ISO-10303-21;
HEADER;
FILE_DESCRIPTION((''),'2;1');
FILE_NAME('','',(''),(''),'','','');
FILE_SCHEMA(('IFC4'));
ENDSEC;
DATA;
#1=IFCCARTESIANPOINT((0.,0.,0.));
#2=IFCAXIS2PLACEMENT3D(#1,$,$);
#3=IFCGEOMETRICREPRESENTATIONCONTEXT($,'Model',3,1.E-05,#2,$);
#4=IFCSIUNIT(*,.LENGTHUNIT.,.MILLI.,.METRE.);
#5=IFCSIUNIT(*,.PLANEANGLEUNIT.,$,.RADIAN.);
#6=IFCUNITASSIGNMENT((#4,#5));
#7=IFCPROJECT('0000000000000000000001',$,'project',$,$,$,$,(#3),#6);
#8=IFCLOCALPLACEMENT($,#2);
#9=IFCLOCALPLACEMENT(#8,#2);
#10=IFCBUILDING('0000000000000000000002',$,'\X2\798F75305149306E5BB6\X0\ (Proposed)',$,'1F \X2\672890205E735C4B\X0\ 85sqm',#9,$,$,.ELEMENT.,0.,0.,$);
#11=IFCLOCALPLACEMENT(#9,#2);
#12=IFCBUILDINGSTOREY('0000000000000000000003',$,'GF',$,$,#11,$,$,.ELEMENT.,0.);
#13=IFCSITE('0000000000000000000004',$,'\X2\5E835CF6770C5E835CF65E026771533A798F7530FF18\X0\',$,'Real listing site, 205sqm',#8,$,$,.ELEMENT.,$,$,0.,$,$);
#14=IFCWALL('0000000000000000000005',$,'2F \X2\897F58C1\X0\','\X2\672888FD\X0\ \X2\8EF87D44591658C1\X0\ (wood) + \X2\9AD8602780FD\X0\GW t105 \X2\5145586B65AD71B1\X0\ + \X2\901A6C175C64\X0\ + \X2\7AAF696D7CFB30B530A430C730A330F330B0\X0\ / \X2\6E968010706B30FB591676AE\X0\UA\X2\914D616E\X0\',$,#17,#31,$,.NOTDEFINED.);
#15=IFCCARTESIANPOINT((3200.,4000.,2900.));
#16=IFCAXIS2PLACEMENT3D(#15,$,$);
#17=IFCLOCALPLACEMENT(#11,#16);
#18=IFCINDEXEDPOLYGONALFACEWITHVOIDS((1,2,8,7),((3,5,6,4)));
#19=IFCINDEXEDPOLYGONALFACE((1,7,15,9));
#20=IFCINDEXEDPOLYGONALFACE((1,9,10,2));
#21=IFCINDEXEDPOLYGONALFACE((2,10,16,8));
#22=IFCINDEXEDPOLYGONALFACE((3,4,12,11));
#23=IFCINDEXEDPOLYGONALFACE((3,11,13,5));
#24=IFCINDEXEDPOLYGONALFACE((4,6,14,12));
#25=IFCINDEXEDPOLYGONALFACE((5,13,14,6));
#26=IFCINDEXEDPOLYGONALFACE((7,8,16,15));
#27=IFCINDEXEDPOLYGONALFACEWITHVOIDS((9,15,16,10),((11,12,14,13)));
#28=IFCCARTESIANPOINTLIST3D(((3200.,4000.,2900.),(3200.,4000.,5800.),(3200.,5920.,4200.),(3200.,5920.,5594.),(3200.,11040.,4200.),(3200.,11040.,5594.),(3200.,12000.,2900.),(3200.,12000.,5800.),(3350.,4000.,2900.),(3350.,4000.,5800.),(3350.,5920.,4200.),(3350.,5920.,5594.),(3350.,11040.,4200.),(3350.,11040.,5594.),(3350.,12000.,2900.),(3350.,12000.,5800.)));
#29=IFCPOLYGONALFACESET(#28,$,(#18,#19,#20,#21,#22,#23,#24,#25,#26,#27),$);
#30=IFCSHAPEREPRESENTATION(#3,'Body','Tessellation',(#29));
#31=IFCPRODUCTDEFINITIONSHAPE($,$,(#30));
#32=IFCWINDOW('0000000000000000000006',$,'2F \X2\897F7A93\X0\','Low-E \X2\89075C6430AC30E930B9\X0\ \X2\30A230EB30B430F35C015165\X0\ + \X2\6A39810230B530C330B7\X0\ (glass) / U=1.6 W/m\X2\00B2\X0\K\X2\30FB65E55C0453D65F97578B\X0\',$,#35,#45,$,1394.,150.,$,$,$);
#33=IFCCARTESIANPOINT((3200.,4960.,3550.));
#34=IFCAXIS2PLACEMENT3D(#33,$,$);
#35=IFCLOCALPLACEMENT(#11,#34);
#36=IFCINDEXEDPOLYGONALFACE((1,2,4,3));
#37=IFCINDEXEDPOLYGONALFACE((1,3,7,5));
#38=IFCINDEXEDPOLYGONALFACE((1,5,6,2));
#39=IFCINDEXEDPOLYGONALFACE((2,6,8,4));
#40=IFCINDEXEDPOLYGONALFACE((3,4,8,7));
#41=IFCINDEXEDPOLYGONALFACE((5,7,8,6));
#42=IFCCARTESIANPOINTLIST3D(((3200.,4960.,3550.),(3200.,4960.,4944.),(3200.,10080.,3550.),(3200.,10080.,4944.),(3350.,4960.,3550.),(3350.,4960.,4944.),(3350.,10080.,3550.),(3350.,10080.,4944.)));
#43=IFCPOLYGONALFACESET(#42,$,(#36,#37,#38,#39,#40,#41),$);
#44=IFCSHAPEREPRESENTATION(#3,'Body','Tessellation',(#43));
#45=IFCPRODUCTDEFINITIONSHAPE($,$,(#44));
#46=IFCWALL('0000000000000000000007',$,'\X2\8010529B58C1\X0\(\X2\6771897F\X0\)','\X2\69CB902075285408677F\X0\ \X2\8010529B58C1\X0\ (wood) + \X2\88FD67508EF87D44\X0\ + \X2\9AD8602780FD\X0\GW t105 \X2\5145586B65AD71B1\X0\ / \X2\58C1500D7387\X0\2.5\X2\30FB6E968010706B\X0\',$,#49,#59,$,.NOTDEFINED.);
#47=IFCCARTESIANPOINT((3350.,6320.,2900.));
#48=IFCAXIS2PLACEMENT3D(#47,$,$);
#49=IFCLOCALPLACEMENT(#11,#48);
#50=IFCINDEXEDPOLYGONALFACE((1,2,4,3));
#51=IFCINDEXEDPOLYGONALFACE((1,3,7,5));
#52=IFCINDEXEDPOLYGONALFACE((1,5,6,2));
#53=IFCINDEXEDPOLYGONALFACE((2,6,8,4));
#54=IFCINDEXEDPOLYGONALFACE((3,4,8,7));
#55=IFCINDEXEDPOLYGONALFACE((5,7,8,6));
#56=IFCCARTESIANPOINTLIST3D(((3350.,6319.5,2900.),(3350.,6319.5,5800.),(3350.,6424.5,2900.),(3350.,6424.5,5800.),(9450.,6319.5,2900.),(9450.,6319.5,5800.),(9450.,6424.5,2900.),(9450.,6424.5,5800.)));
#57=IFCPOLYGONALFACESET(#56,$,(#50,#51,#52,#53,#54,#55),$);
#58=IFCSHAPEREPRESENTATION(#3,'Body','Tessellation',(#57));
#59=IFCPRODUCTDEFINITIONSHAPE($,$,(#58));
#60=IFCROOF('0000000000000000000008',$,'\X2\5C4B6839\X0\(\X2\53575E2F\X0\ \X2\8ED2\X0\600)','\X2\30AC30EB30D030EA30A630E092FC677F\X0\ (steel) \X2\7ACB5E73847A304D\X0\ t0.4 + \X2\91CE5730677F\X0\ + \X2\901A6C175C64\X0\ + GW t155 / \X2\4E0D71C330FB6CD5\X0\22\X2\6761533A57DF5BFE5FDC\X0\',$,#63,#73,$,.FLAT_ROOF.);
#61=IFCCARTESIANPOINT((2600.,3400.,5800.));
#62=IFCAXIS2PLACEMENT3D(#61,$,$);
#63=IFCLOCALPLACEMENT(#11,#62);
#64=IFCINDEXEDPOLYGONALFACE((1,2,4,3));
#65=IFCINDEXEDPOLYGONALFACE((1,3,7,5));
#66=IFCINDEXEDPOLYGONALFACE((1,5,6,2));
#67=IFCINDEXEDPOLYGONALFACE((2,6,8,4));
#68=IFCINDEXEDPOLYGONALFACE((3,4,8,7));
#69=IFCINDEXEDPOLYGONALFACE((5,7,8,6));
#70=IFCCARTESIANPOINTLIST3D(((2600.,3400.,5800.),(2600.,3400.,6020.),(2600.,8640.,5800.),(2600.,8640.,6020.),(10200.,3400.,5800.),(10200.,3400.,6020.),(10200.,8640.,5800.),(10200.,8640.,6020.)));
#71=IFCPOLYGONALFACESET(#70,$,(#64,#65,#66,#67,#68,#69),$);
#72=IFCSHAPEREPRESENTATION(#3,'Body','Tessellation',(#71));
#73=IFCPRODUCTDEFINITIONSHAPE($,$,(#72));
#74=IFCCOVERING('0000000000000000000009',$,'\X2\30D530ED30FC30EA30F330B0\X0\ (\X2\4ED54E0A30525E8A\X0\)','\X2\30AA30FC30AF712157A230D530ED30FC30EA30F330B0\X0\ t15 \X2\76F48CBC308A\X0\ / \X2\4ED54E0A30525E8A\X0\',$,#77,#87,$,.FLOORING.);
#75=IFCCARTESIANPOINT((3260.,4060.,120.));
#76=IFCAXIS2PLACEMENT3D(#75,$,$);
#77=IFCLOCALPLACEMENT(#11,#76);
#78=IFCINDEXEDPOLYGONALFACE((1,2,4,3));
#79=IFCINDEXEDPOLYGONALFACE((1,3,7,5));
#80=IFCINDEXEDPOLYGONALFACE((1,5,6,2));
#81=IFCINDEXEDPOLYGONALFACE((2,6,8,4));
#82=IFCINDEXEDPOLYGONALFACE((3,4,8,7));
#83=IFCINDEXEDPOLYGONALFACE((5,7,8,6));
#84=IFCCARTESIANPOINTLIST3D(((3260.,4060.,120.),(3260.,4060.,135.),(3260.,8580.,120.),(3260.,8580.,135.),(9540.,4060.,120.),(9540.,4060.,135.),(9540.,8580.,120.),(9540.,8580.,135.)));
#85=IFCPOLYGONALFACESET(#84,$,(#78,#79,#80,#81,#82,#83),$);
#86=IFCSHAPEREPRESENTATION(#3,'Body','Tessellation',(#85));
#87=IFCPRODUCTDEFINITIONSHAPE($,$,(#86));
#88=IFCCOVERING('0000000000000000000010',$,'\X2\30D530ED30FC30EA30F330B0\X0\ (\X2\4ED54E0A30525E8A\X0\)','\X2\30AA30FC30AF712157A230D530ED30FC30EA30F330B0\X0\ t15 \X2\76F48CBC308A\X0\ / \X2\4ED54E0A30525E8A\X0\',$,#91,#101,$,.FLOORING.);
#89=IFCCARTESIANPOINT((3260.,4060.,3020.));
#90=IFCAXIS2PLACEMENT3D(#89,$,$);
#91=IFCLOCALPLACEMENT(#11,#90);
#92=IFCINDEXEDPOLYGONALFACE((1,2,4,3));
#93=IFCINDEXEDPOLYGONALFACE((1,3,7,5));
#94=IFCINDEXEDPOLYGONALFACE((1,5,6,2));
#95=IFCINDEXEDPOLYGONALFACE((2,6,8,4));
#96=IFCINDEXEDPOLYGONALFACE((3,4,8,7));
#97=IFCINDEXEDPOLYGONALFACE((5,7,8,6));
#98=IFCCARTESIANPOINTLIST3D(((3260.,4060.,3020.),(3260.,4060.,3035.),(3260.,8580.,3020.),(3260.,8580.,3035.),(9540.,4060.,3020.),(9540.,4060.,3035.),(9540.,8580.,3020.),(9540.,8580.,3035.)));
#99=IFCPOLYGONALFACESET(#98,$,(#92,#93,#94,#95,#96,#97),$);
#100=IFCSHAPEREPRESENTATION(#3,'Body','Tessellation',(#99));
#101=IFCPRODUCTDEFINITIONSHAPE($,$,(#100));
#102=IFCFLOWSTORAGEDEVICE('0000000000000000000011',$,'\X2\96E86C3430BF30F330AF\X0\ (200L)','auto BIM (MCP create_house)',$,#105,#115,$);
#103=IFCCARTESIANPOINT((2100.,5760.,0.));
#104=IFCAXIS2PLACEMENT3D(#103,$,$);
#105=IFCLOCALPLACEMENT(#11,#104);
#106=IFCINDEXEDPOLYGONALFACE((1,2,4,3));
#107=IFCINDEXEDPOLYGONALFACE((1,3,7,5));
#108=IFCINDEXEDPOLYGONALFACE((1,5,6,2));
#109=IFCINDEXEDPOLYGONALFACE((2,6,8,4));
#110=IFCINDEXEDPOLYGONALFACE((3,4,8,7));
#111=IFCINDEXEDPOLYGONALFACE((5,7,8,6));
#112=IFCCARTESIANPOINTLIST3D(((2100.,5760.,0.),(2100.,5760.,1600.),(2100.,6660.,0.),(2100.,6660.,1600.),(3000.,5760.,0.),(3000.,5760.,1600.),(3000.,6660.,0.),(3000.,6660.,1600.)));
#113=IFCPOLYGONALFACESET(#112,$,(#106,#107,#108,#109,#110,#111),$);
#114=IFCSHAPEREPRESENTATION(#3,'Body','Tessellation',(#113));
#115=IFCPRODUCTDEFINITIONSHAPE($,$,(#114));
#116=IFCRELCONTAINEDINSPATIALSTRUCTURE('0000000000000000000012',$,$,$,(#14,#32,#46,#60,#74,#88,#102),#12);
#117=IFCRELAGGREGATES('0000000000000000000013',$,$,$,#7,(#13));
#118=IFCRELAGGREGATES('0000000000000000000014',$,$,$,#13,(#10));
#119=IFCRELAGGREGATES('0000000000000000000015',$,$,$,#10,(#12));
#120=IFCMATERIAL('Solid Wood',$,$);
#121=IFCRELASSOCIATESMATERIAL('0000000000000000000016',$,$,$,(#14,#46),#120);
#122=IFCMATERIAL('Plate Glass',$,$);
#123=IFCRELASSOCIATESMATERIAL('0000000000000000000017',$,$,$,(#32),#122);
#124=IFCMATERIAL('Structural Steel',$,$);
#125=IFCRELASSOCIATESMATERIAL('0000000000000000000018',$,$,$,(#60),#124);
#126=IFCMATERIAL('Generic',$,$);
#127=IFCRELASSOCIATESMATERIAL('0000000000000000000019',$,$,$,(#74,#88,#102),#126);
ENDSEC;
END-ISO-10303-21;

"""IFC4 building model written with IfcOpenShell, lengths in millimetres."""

from ifc_helpers import new_model, si_unit, frame, frame_2d, origin, place, context, project, spatial, rectangle, extrude, material, element, fill, save


model = new_model("IFC4")

# Units and contexts
model_context = context("Model", 3, precision=1e-05, world=origin())
ifc_project = project(units=[si_unit("LENGTHUNIT", "METRE", prefix="MILLI"), si_unit("PLANEANGLEUNIT", "RADIAN")], contexts=[model_context])

# Site, building, storey
site_placement = place(None, origin())
site = spatial("IfcSite", under=ifc_project, at=site_placement, Name="広島県広島市東区福田８", ObjectType="Real listing site, 205sqm", CompositionType="ELEMENT", RefElevation=0.0)
building_placement = place(site_placement, origin())
building = spatial("IfcBuilding", under=site, at=building_placement, Name="福田光の家 (Proposed)", ObjectType="1F 木造平屋 85sqm", CompositionType="ELEMENT", ElevationOfRefHeight=0.0, ElevationOfTerrain=0.0)
storey_placement = place(building_placement, origin())
storey = spatial("IfcBuildingStorey", under=building, at=storey_placement, Name="GF", CompositionType="ELEMENT", Elevation=0.0)

# Shared definitions
ifc_material_1 = material(Name="Solid Wood")
ifc_material_2 = material(Name="Generic")

# Shared definitions
ifc_material_3 = material(Name="Plate Glass")

# Wall, opening, window
wall_1_placement = place(storey_placement, frame((3200.0, 4000.0, 2900.0)))
wall_1 = element("IfcWall", 1, at=wall_1_placement, inside=storey, material=ifc_material_1, Name="2F 西壁", Description="木製 軸組外壁 (wood) + 高性能GW t105 充填断熱 + 通気層 + 窯業系サイディング / 準耐火・外皮UA配慮", PredefinedType="NOTDEFINED", context=model_context, shape_type="SweptSolid", body=[
    extrude(rectangle(XDim=150.0, YDim=8000.0, at=frame_2d((75.0, 4000.0))), frame((3200.0, 4000.0, 2900.0)), (0.0, 0.0, 1.0), 2900.0),
])
opening_1_placement = place(storey_placement, frame((3200.0, 4960.0, 3550.0)))
opening_1 = element("IfcOpeningElement", 2, at=opening_1_placement, cuts=wall_1, PredefinedType="NOTDEFINED", context=model_context, shape_type="SweptSolid", body=[
    extrude(rectangle(XDim=150.0, YDim=5120.0, at=frame_2d((75.0, 2560.0))), frame((3200.0, 4960.0, 3550.0)), (0.0, 0.0, 1.0), 1394.0),
])
window_1_placement = place(storey_placement, frame((3200.0, 4960.0, 3550.0)))
window_1 = element("IfcWindow", 3, at=window_1_placement, inside=storey, material=ifc_material_3, Name="2F 西窓", Description="Low-E 複層ガラス アルゴン封入 + 樹脂サッシ (glass) / U=1.6 W/m²K・日射取得型", OverallHeight=1394.0, OverallWidth=150.0, context=model_context, shape_type="SweptSolid", body=[
    extrude(rectangle(XDim=150.0, YDim=5120.0, at=frame_2d((75.0, 2560.0))), frame((3200.0, 4960.0, 3550.0)), (0.0, 0.0, 1.0), 1394.0),
])
fill(opening_1, window_1)

# Wall
wall_2_placement = place(storey_placement, frame((3350.0, 6320.0, 2900.0)))
element("IfcWall", 4, at=wall_2_placement, inside=storey, material=ifc_material_1, Name="耐力壁(東西)", Description="構造用合板 耐力壁 (wood) + 製材軸組 + 高性能GW t105 充填断熱 / 壁倍率2.5・準耐火", PredefinedType="NOTDEFINED", context=model_context, shape_type="SweptSolid", body=[
    extrude(rectangle(XDim=6100.0, YDim=105.0, at=frame_2d((3050.0, 52.0))), frame((3350.0, 6320.0, 2900.0)), (0.0, 0.0, 1.0), 2900.0),
])

# Roof
ifc_material_4 = material(Name="Structural Steel")
for number, where, name in (
    (5, (2600.0, 3400.0, 5800.0), "屋根(南帯 軒600)"),
):
    element("IfcRoof", number, at=place(storey_placement, frame(where)), inside=storey, material=ifc_material_4, Name=name, Description="ガルバリウム鋼板 (steel) 立平葺き t0.4 + 野地板 + 通気層 + GW t155 / 不燃・法22条区域対応", PredefinedType="FLAT_ROOF", context=model_context, shape_type="SweptSolid", body=[
        extrude(rectangle(XDim=7600.0, YDim=5240.0, at=frame_2d((3800.0, 2620.0))), frame((2600.0, 3400.0, 5800.0)), (0.0, 0.0, 1.0), 220.0),
    ])

# Coverings
covering_1_placement = place(storey_placement, frame((3260.0, 4060.0, 120.0)))
element("IfcCovering", 6, at=covering_1_placement, inside=storey, material=ifc_material_2, Name="フローリング (仕上げ床)", Description="オーク無垢フローリング t15 直貼り / 仕上げ床", PredefinedType="FLOORING", context=model_context, shape_type="SweptSolid", body=[
    extrude(rectangle(XDim=6280.0, YDim=4520.0, at=frame_2d((3140.0, 2260.0))), frame((3260.0, 4060.0, 120.0)), (0.0, 0.0, 1.0), 15.0),
])
covering_2_placement = place(storey_placement, frame((3260.0, 4060.0, 3020.0)))
element("IfcCovering", 7, at=covering_2_placement, inside=storey, material=ifc_material_2, Name="フローリング (仕上げ床)", Description="オーク無垢フローリング t15 直貼り / 仕上げ床", PredefinedType="FLOORING", context=model_context, shape_type="SweptSolid", body=[
    extrude(rectangle(XDim=6280.0, YDim=4520.0, at=frame_2d((3140.0, 2260.0))), frame((3260.0, 4060.0, 3020.0)), (0.0, 0.0, 1.0), 15.0),
])

# Flow storage device
flow_storage_device_placement = place(storey_placement, frame((2100.0, 5760.0, 0.0)))
element("IfcFlowStorageDevice", 8, at=flow_storage_device_placement, inside=storey, material=ifc_material_2, Name="雨水タンク (200L)", Description="auto BIM (MCP create_house)", context=model_context, shape_type="SweptSolid", body=[
    extrude(rectangle(XDim=900.0, YDim=900.0, at=frame_2d((450.0, 450.0))), frame((2100.0, 5760.0, 0.0)), (0.0, 0.0, 1.0), 1600.0),
])

save(model, "model.ifc")
